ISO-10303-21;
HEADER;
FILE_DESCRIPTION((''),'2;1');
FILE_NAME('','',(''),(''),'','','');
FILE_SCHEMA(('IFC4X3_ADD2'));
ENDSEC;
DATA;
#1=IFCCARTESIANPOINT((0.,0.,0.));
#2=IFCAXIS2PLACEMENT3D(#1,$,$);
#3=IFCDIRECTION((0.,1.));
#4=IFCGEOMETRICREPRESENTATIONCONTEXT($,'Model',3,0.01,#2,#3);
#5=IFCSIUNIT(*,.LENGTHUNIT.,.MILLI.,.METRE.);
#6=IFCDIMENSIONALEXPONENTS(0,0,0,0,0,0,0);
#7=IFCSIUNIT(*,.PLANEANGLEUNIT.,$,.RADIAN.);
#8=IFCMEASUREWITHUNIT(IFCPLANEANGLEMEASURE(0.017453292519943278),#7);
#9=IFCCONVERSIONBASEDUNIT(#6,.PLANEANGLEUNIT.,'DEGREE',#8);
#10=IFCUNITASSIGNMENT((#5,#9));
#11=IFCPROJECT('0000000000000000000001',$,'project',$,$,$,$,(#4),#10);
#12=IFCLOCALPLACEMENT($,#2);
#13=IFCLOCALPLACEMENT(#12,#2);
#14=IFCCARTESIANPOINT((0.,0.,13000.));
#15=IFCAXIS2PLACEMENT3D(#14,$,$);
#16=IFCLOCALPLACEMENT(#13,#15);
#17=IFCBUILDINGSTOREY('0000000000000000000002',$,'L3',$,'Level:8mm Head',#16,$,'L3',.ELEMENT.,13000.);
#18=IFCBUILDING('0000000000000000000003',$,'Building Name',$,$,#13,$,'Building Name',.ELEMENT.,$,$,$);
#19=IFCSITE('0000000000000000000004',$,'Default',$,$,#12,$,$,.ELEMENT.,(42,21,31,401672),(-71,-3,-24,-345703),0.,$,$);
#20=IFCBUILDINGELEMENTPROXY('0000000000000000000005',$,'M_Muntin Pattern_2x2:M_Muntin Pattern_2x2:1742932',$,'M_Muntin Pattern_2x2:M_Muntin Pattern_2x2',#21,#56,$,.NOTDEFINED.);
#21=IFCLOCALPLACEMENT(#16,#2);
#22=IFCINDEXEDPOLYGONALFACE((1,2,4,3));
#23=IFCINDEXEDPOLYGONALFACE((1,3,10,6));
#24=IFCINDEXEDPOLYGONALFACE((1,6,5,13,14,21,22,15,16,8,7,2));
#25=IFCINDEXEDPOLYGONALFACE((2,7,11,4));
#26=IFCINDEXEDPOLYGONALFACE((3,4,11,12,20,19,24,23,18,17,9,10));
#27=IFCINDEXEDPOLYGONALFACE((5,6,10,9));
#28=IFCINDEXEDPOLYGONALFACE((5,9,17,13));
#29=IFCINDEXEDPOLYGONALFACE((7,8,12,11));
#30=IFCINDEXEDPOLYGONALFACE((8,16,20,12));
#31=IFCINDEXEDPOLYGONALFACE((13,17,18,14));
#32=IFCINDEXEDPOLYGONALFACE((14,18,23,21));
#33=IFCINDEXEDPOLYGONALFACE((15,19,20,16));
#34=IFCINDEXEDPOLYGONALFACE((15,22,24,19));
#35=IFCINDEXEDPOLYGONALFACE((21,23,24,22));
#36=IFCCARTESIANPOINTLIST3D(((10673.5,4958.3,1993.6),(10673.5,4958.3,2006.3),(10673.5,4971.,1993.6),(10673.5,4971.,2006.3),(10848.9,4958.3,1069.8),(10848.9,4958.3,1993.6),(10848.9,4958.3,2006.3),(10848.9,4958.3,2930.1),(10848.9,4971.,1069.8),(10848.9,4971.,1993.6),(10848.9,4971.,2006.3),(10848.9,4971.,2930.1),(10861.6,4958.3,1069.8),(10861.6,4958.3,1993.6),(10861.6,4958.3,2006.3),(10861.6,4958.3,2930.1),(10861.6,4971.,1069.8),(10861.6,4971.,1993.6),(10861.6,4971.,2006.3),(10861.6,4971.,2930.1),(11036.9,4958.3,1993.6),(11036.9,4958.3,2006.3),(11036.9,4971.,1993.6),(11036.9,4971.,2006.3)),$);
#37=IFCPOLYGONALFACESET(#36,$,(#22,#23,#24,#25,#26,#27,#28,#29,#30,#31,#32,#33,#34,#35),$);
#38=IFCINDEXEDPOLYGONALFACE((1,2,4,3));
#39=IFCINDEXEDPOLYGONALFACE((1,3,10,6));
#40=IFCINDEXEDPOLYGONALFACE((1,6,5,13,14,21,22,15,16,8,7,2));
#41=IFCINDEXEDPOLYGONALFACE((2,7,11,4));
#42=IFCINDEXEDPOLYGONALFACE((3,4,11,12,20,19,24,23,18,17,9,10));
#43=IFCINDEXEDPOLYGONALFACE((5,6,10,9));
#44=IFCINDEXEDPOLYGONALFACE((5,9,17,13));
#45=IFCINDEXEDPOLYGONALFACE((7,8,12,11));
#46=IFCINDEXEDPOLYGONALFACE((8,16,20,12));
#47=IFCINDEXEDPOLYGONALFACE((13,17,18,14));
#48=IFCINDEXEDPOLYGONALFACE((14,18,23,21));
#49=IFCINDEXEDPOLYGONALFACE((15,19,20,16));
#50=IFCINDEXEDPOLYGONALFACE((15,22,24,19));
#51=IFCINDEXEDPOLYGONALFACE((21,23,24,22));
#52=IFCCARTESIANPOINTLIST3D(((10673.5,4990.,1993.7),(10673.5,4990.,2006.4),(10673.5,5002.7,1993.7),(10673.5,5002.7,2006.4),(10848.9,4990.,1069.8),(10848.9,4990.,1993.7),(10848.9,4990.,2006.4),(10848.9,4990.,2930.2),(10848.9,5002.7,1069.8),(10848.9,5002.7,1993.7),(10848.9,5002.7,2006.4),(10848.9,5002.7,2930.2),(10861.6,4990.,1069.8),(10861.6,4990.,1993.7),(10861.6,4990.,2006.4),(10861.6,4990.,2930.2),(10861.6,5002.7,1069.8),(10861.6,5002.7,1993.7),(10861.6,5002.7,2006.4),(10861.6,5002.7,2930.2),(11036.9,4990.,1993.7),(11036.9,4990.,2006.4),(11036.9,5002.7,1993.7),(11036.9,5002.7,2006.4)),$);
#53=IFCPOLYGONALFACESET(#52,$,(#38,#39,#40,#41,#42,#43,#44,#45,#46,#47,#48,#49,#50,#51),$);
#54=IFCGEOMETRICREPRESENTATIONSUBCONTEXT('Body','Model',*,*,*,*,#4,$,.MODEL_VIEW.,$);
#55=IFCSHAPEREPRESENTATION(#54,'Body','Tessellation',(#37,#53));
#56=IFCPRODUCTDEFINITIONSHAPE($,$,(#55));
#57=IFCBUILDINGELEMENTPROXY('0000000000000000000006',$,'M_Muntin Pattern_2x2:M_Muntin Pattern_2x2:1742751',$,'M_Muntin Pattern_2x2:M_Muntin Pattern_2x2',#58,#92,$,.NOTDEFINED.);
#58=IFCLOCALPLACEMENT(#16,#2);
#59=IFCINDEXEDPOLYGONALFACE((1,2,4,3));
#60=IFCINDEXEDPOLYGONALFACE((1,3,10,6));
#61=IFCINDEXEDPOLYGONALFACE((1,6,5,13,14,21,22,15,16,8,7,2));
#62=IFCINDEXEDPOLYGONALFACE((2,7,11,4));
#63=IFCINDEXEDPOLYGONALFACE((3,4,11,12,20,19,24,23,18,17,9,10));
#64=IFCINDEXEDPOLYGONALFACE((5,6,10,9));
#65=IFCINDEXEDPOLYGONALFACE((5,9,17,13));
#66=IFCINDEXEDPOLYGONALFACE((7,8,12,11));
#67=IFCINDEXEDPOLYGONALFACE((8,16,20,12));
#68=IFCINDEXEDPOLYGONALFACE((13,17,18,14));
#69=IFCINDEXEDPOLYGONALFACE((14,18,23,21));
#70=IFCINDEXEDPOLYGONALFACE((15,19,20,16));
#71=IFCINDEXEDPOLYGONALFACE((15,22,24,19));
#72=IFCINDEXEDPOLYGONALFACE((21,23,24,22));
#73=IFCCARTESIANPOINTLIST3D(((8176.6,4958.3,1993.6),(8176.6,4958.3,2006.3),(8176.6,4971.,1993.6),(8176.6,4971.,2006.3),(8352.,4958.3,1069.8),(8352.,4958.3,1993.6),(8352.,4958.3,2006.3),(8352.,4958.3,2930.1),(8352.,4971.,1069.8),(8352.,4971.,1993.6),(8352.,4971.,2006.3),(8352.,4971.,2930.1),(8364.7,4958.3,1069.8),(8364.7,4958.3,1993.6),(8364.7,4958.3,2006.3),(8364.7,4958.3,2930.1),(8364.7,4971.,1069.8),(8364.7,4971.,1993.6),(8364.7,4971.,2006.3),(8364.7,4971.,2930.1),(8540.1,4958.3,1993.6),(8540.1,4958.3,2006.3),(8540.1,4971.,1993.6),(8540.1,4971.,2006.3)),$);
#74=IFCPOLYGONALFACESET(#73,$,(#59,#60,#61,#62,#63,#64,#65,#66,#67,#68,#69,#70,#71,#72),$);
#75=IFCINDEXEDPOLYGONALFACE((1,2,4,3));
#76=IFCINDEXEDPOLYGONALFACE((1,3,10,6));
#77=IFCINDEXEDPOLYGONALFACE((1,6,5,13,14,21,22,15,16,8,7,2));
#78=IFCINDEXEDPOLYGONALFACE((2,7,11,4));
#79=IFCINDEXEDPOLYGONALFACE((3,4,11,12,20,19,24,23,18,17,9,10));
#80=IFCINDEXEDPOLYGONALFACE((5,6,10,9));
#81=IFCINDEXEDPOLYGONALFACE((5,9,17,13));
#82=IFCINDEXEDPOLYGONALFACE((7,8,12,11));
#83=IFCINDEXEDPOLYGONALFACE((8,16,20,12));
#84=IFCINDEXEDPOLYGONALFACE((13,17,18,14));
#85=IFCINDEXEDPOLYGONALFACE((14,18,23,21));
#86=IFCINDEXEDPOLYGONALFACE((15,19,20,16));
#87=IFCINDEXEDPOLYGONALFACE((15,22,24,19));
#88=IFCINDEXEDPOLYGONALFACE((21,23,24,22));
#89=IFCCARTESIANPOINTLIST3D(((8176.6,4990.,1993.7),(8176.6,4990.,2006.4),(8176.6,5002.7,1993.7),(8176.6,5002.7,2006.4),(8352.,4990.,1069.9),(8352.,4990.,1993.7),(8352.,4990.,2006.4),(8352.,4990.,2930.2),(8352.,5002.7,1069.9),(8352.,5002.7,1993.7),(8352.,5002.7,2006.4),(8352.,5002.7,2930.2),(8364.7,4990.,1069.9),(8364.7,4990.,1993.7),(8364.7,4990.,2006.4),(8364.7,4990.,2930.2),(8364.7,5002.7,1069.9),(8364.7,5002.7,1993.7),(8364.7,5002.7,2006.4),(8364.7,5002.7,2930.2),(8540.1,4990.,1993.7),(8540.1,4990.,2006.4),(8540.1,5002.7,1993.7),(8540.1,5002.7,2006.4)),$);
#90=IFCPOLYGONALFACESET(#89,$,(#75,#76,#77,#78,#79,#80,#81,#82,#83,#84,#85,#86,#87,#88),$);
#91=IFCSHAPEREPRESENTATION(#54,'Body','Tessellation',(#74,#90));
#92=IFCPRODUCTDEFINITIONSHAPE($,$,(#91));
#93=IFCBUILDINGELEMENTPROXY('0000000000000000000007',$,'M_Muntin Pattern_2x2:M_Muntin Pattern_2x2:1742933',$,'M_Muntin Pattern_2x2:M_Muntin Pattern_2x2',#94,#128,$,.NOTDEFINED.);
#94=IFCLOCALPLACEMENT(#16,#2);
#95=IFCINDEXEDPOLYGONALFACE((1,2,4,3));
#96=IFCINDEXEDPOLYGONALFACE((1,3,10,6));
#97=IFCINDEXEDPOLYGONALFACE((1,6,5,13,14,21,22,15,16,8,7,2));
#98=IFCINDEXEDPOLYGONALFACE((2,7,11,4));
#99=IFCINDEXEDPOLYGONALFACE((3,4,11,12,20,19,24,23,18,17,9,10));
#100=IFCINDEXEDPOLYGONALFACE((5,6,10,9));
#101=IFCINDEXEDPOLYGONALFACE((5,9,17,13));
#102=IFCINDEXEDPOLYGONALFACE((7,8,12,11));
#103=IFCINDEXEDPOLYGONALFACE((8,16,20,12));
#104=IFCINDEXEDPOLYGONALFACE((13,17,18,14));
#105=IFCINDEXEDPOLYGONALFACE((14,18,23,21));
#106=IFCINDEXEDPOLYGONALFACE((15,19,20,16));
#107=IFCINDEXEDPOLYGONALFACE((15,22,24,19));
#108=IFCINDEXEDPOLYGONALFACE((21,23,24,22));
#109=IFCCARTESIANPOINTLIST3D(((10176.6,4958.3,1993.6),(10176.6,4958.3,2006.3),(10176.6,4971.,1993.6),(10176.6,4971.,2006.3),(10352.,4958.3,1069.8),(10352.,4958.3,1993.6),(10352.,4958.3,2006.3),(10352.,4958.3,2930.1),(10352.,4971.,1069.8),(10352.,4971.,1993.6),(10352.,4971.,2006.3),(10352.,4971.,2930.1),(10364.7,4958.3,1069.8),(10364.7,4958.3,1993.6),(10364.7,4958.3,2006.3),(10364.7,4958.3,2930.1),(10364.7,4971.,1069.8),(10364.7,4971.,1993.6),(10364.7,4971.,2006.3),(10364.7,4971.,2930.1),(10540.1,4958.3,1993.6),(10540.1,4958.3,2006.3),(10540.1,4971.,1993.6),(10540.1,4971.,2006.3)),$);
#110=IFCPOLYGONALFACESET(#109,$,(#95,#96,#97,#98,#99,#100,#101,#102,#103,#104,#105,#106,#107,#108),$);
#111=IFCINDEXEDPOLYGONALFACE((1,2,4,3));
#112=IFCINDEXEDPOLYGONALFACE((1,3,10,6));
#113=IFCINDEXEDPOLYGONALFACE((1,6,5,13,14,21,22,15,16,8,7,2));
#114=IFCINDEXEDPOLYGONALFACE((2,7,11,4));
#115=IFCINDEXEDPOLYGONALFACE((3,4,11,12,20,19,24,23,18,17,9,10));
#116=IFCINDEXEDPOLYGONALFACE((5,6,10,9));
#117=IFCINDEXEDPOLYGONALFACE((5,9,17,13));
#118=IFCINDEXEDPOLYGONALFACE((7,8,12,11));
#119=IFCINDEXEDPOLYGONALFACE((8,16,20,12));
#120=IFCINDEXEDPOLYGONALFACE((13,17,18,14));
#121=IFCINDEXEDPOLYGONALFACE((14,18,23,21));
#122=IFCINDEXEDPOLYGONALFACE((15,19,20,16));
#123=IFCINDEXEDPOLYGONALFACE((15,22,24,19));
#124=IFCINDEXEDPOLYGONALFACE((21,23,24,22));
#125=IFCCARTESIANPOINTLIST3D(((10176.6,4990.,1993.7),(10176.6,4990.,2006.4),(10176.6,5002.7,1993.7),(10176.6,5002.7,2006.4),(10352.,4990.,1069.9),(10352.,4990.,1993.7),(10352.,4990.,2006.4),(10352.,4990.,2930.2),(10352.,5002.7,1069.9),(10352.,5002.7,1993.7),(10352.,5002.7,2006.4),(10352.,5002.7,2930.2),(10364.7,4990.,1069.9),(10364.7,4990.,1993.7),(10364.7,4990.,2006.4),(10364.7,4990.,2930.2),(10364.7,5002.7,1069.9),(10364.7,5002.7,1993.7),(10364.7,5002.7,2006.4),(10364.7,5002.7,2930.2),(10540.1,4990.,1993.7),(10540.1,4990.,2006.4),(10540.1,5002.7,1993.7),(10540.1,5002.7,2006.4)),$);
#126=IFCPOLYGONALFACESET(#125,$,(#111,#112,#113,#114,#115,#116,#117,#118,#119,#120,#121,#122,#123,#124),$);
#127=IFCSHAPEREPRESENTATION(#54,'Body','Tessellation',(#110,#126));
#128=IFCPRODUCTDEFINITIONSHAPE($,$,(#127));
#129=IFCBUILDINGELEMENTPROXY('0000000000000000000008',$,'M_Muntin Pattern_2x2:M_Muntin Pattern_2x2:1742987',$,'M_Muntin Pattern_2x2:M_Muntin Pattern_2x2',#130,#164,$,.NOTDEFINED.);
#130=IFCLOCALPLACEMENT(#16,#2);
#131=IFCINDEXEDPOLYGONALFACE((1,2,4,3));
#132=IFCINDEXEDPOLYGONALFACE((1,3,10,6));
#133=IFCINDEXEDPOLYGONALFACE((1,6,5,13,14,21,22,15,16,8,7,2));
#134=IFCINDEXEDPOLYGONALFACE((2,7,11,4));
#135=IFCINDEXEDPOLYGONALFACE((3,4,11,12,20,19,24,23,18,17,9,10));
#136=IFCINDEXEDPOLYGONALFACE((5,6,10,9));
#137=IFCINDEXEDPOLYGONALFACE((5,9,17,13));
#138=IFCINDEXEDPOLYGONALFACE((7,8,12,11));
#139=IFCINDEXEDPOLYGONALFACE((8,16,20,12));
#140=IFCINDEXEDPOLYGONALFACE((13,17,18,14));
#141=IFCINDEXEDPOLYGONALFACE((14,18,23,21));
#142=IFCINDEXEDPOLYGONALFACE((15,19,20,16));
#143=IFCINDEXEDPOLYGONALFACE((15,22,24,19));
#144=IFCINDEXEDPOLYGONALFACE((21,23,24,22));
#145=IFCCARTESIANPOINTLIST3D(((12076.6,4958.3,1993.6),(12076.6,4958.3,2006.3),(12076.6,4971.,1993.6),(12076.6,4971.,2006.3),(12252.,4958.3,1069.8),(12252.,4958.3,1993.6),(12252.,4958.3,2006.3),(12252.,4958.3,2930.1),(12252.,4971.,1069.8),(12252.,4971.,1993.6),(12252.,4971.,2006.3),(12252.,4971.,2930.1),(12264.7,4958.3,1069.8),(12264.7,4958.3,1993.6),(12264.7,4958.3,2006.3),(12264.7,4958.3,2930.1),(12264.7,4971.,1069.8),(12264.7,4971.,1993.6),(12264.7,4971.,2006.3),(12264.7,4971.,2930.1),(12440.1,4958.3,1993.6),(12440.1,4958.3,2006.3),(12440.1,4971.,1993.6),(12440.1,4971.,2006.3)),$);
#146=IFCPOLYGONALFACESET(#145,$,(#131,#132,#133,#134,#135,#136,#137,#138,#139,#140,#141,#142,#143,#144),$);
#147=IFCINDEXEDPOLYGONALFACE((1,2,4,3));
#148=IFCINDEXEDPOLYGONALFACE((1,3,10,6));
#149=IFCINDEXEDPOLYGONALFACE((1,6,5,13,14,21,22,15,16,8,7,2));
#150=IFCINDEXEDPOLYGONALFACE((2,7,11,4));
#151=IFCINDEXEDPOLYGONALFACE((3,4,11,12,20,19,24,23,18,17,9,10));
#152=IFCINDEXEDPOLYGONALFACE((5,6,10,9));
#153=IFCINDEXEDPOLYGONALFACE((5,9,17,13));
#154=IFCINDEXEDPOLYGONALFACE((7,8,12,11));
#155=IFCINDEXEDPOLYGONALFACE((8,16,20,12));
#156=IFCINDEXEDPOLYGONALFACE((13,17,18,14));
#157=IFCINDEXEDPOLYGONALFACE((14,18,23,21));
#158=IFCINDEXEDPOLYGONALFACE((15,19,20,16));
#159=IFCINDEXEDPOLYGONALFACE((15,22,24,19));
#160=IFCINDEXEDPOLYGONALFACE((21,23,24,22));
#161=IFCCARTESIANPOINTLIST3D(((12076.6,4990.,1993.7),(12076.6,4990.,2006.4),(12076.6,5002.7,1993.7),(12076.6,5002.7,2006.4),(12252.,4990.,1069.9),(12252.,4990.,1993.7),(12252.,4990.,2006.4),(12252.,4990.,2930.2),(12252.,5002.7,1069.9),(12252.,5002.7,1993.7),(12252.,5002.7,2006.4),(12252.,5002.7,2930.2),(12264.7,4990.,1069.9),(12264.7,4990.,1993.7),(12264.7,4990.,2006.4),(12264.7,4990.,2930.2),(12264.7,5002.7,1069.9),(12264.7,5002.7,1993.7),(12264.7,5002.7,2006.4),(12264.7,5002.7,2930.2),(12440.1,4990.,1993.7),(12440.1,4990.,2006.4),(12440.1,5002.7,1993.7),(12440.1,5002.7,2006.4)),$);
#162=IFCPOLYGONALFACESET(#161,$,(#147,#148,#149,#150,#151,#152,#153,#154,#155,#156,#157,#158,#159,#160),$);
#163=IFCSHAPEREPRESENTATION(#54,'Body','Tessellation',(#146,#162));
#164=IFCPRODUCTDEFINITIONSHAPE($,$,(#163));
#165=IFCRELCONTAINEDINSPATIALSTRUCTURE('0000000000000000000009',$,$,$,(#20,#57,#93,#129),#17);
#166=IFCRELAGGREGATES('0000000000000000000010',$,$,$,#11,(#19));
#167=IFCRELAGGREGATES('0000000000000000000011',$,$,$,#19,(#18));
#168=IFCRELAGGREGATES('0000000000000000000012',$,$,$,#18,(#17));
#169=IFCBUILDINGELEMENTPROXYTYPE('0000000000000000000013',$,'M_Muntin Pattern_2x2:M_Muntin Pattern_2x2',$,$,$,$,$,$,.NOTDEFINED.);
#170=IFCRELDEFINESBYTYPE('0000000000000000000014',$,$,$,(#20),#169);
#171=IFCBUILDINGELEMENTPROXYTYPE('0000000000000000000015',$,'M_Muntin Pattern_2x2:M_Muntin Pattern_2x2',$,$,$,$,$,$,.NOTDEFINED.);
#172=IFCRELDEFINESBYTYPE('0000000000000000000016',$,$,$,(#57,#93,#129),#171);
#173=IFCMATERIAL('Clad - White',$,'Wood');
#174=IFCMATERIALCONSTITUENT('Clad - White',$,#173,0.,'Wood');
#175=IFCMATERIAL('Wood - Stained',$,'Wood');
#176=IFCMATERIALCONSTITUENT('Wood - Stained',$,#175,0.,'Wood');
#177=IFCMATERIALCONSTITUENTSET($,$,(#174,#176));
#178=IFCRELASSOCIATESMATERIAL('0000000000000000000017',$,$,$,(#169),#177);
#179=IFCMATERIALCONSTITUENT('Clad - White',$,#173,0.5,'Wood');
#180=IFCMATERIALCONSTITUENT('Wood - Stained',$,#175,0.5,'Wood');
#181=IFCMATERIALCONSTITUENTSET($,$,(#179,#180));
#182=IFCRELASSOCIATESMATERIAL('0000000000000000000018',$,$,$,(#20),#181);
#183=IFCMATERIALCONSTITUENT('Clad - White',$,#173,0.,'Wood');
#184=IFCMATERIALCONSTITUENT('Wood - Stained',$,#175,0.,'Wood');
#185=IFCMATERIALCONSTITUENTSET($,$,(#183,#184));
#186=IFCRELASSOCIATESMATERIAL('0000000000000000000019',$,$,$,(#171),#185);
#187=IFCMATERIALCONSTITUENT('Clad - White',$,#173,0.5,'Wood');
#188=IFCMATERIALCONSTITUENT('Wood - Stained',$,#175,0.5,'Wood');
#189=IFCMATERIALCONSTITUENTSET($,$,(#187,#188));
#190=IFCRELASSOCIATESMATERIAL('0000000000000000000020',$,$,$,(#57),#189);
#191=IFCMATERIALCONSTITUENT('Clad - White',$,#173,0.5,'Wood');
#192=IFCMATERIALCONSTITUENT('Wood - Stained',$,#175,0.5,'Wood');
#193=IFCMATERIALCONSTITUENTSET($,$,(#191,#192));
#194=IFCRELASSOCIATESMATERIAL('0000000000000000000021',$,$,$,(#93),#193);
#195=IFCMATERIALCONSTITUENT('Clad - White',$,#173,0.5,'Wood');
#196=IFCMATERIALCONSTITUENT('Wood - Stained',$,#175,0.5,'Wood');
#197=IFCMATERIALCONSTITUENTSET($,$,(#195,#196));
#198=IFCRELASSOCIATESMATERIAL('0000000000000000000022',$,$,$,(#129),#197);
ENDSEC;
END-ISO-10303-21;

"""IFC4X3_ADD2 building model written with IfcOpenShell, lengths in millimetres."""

from ifc_helpers import new_model, entity, si_unit, converted_unit, direction, frame, origin, place, context, subcontext, project, spatial, polyline, outline, extrude, source, transform, mapped, material, constituent, constituent_set, type_object, type_shapes, element, save


model = new_model("IFC4X3_ADD2")

# Units and contexts
model_context = context("Model", 3, precision=0.01, world=origin(), true_north=direction((0.0, 1.0)))
body_context = subcontext(model_context, "Body", "Model", "MODEL_VIEW")
ifc_project = project(units=[si_unit("LENGTHUNIT", "METRE", prefix="MILLI"), converted_unit("PLANEANGLEUNIT", "DEGREE", entity("IfcPlaneAngleMeasure", 0.017453292519943278), si_unit("PLANEANGLEUNIT", "RADIAN"), dimensions=[0, 0, 0, 0, 0, 0, 0])], contexts=[model_context])

# Site, building, storey
site_placement = place(None, origin())
site = spatial("IfcSite", under=ifc_project, at=site_placement, Name="Default", CompositionType="ELEMENT", RefLatitude=(42, 21, 31, 401672), RefLongitude=(-71, -3, -24, -345703), RefElevation=0.0)
building_placement = place(site_placement, origin())
building = spatial("IfcBuilding", under=site, at=building_placement, Name="Building Name", LongName="Building Name", CompositionType="ELEMENT")
storey_placement = place(building_placement, frame((0.0, 0.0, 13000.0)))
storey = spatial("IfcBuildingStorey", under=building, at=storey_placement, Name="L3", ObjectType="Level:8mm Head", LongName="L3", CompositionType="ELEMENT", Elevation=13000.0)

# Building element proxies
ifc_material_1 = material(Name="Clad - White", Category="Wood")
ifc_material_2 = material(Name="Wood - Stained", Category="Wood")
ifc_constituent_1 = constituent(ifc_material_1, Name="Clad - White", Category="Wood", fraction=0.0)
ifc_constituent_2 = constituent(ifc_material_2, Name="Wood - Stained", Category="Wood", fraction=0.0)
ifc_constituent_set_1 = constituent_set(constituents=[ifc_constituent_1, ifc_constituent_2])
building_element_proxy_type_1 = type_object("IfcBuildingElementProxyType", Name="M_Muntin Pattern_2x2:M_Muntin Pattern_2x2", PredefinedType="NOTDEFINED", material=ifc_constituent_set_1)
shared_shape_1 = source(origin(), body_context, "Body", "SweptSolid", [
    extrude(outline(polyline([(6.4, -6.4), (930.1, -6.4), (930.1, 6.3), (6.4, 6.3), (6.4, 181.7), (-6.3, 181.7), (-6.3, 6.3), (-930.2, 6.3), (-930.2, -6.4), (-6.3, -6.4), (-6.3, -181.7), (6.4, -181.7), (6.4, -6.4)])), frame((0.0, 9.5, 930.1), z_axis=(0.0, 1.0, 0.0), x_axis=(0.0, 0.0, 1.0)), (0.0, 0.0, 1.0), 12.7),
    extrude(outline(polyline([(6.4, -6.4), (930.2, -6.4), (930.2, 6.3), (6.4, 6.3), (6.4, 181.7), (-6.3, 181.7), (-6.3, 6.3), (-930.2, 6.3), (-930.2, -6.4), (-6.3, -6.4), (-6.3, -181.7), (6.4, -181.7), (6.4, -6.4)])), frame((0.0, -22.2, 930.2), z_axis=(0.0, 1.0, 0.0), x_axis=(0.0, 0.0, 1.0)), (0.0, 0.0, 1.0), 12.7),
])
type_shapes(building_element_proxy_type_1, [shared_shape_1])
ifc_constituent_3 = constituent(ifc_material_1, Name="Clad - White", Category="Wood", fraction=0.5)
ifc_constituent_4 = constituent(ifc_material_2, Name="Wood - Stained", Category="Wood", fraction=0.5)
ifc_constituent_set_2 = constituent_set(constituents=[ifc_constituent_3, ifc_constituent_4])
proxy_1_placement = place(storey_placement, frame((10855.2, 4980.5, 1069.8), z_axis=(0.0, 0.0, 1.0), x_axis=(-1.0, 0.0, 0.0)))
element("IfcBuildingElementProxy", 1, at=proxy_1_placement, inside=storey, type_object=building_element_proxy_type_1, material=ifc_constituent_set_2, Name="M_Muntin Pattern_2x2:M_Muntin Pattern_2x2:1742932", ObjectType="M_Muntin Pattern_2x2:M_Muntin Pattern_2x2", PredefinedType="NOTDEFINED", context=body_context, shape_type="MappedRepresentation", body=[
    mapped(shared_shape_1, transform((0.0, 0.0, 0.0), scale=1.0)),
])
ifc_constituent_5 = constituent(ifc_material_1, Name="Clad - White", Category="Wood", fraction=0.5)
ifc_constituent_6 = constituent(ifc_material_2, Name="Wood - Stained", Category="Wood", fraction=0.5)
ifc_constituent_set_3 = constituent_set(constituents=[ifc_constituent_5, ifc_constituent_6])
ifc_constituent_7 = constituent(ifc_material_1, Name="Clad - White", Category="Wood", fraction=0.0)
ifc_constituent_8 = constituent(ifc_material_2, Name="Wood - Stained", Category="Wood", fraction=0.0)
ifc_constituent_set_4 = constituent_set(constituents=[ifc_constituent_7, ifc_constituent_8])
building_element_proxy_type_2 = type_object("IfcBuildingElementProxyType", Name="M_Muntin Pattern_2x2:M_Muntin Pattern_2x2", PredefinedType="NOTDEFINED", material=ifc_constituent_set_4)
shared_shape_2 = source(origin(), body_context, "Body", "SweptSolid", [
    extrude(outline(polyline([(6.4, -6.4), (930.1, -6.4), (930.1, 6.3), (6.4, 6.3), (6.4, 181.7), (-6.3, 181.7), (-6.3, 6.3), (-930.2, 6.3), (-930.2, -6.4), (-6.3, -6.4), (-6.3, -181.7), (6.4, -181.7), (6.4, -6.4)])), frame((0.0, -22.2, 930.1), z_axis=(0.0, 1.0, 0.0), x_axis=(0.0, 0.0, 1.0)), (0.0, 0.0, 1.0), 12.7),
    extrude(outline(polyline([(6.4, -6.4), (930.2, -6.4), (930.2, 6.3), (6.4, 6.3), (6.4, 181.7), (-6.3, 181.7), (-6.3, 6.3), (-930.2, 6.3), (-930.2, -6.4), (-6.3, -6.4), (-6.3, -181.7), (6.4, -181.7), (6.4, -6.4)])), frame((0.0, 9.5, 930.2), z_axis=(0.0, 1.0, 0.0), x_axis=(0.0, 0.0, 1.0)), (0.0, 0.0, 1.0), 12.7),
])
type_shapes(building_element_proxy_type_2, [shared_shape_2])
proxy_2_placement = place(storey_placement, frame((8358.4, 4980.5, 1069.9)))
element("IfcBuildingElementProxy", 2, at=proxy_2_placement, inside=storey, type_object=building_element_proxy_type_2, material=ifc_constituent_set_3, Name="M_Muntin Pattern_2x2:M_Muntin Pattern_2x2:1742751", ObjectType="M_Muntin Pattern_2x2:M_Muntin Pattern_2x2", PredefinedType="NOTDEFINED", context=body_context, shape_type="MappedRepresentation", body=[
    mapped(shared_shape_2, transform((0.0, 0.0, 0.0), scale=1.0)),
])
ifc_constituent_9 = constituent(ifc_material_1, Name="Clad - White", Category="Wood", fraction=0.5)
ifc_constituent_10 = constituent(ifc_material_2, Name="Wood - Stained", Category="Wood", fraction=0.5)
ifc_constituent_set_5 = constituent_set(constituents=[ifc_constituent_9, ifc_constituent_10])
proxy_3_placement = place(storey_placement, frame((10358.4, 4980.5, 1069.9)))
element("IfcBuildingElementProxy", 3, at=proxy_3_placement, inside=storey, type_object=building_element_proxy_type_2, material=ifc_constituent_set_5, Name="M_Muntin Pattern_2x2:M_Muntin Pattern_2x2:1742933", ObjectType="M_Muntin Pattern_2x2:M_Muntin Pattern_2x2", PredefinedType="NOTDEFINED", context=body_context, shape_type="MappedRepresentation", body=[
    mapped(shared_shape_2, transform((0.0, 0.0, 0.0), scale=1.0)),
])
ifc_constituent_11 = constituent(ifc_material_1, Name="Clad - White", Category="Wood", fraction=0.5)
ifc_constituent_12 = constituent(ifc_material_2, Name="Wood - Stained", Category="Wood", fraction=0.5)
ifc_constituent_set_6 = constituent_set(constituents=[ifc_constituent_11, ifc_constituent_12])
proxy_4_placement = place(storey_placement, frame((12258.4, 4980.5, 1069.9)))
element("IfcBuildingElementProxy", 4, at=proxy_4_placement, inside=storey, type_object=building_element_proxy_type_2, material=ifc_constituent_set_6, Name="M_Muntin Pattern_2x2:M_Muntin Pattern_2x2:1742987", ObjectType="M_Muntin Pattern_2x2:M_Muntin Pattern_2x2", PredefinedType="NOTDEFINED", context=body_context, shape_type="MappedRepresentation", body=[
    mapped(shared_shape_2, transform((0.0, 0.0, 0.0), scale=1.0)),
])

save(model, "model.ifc")
